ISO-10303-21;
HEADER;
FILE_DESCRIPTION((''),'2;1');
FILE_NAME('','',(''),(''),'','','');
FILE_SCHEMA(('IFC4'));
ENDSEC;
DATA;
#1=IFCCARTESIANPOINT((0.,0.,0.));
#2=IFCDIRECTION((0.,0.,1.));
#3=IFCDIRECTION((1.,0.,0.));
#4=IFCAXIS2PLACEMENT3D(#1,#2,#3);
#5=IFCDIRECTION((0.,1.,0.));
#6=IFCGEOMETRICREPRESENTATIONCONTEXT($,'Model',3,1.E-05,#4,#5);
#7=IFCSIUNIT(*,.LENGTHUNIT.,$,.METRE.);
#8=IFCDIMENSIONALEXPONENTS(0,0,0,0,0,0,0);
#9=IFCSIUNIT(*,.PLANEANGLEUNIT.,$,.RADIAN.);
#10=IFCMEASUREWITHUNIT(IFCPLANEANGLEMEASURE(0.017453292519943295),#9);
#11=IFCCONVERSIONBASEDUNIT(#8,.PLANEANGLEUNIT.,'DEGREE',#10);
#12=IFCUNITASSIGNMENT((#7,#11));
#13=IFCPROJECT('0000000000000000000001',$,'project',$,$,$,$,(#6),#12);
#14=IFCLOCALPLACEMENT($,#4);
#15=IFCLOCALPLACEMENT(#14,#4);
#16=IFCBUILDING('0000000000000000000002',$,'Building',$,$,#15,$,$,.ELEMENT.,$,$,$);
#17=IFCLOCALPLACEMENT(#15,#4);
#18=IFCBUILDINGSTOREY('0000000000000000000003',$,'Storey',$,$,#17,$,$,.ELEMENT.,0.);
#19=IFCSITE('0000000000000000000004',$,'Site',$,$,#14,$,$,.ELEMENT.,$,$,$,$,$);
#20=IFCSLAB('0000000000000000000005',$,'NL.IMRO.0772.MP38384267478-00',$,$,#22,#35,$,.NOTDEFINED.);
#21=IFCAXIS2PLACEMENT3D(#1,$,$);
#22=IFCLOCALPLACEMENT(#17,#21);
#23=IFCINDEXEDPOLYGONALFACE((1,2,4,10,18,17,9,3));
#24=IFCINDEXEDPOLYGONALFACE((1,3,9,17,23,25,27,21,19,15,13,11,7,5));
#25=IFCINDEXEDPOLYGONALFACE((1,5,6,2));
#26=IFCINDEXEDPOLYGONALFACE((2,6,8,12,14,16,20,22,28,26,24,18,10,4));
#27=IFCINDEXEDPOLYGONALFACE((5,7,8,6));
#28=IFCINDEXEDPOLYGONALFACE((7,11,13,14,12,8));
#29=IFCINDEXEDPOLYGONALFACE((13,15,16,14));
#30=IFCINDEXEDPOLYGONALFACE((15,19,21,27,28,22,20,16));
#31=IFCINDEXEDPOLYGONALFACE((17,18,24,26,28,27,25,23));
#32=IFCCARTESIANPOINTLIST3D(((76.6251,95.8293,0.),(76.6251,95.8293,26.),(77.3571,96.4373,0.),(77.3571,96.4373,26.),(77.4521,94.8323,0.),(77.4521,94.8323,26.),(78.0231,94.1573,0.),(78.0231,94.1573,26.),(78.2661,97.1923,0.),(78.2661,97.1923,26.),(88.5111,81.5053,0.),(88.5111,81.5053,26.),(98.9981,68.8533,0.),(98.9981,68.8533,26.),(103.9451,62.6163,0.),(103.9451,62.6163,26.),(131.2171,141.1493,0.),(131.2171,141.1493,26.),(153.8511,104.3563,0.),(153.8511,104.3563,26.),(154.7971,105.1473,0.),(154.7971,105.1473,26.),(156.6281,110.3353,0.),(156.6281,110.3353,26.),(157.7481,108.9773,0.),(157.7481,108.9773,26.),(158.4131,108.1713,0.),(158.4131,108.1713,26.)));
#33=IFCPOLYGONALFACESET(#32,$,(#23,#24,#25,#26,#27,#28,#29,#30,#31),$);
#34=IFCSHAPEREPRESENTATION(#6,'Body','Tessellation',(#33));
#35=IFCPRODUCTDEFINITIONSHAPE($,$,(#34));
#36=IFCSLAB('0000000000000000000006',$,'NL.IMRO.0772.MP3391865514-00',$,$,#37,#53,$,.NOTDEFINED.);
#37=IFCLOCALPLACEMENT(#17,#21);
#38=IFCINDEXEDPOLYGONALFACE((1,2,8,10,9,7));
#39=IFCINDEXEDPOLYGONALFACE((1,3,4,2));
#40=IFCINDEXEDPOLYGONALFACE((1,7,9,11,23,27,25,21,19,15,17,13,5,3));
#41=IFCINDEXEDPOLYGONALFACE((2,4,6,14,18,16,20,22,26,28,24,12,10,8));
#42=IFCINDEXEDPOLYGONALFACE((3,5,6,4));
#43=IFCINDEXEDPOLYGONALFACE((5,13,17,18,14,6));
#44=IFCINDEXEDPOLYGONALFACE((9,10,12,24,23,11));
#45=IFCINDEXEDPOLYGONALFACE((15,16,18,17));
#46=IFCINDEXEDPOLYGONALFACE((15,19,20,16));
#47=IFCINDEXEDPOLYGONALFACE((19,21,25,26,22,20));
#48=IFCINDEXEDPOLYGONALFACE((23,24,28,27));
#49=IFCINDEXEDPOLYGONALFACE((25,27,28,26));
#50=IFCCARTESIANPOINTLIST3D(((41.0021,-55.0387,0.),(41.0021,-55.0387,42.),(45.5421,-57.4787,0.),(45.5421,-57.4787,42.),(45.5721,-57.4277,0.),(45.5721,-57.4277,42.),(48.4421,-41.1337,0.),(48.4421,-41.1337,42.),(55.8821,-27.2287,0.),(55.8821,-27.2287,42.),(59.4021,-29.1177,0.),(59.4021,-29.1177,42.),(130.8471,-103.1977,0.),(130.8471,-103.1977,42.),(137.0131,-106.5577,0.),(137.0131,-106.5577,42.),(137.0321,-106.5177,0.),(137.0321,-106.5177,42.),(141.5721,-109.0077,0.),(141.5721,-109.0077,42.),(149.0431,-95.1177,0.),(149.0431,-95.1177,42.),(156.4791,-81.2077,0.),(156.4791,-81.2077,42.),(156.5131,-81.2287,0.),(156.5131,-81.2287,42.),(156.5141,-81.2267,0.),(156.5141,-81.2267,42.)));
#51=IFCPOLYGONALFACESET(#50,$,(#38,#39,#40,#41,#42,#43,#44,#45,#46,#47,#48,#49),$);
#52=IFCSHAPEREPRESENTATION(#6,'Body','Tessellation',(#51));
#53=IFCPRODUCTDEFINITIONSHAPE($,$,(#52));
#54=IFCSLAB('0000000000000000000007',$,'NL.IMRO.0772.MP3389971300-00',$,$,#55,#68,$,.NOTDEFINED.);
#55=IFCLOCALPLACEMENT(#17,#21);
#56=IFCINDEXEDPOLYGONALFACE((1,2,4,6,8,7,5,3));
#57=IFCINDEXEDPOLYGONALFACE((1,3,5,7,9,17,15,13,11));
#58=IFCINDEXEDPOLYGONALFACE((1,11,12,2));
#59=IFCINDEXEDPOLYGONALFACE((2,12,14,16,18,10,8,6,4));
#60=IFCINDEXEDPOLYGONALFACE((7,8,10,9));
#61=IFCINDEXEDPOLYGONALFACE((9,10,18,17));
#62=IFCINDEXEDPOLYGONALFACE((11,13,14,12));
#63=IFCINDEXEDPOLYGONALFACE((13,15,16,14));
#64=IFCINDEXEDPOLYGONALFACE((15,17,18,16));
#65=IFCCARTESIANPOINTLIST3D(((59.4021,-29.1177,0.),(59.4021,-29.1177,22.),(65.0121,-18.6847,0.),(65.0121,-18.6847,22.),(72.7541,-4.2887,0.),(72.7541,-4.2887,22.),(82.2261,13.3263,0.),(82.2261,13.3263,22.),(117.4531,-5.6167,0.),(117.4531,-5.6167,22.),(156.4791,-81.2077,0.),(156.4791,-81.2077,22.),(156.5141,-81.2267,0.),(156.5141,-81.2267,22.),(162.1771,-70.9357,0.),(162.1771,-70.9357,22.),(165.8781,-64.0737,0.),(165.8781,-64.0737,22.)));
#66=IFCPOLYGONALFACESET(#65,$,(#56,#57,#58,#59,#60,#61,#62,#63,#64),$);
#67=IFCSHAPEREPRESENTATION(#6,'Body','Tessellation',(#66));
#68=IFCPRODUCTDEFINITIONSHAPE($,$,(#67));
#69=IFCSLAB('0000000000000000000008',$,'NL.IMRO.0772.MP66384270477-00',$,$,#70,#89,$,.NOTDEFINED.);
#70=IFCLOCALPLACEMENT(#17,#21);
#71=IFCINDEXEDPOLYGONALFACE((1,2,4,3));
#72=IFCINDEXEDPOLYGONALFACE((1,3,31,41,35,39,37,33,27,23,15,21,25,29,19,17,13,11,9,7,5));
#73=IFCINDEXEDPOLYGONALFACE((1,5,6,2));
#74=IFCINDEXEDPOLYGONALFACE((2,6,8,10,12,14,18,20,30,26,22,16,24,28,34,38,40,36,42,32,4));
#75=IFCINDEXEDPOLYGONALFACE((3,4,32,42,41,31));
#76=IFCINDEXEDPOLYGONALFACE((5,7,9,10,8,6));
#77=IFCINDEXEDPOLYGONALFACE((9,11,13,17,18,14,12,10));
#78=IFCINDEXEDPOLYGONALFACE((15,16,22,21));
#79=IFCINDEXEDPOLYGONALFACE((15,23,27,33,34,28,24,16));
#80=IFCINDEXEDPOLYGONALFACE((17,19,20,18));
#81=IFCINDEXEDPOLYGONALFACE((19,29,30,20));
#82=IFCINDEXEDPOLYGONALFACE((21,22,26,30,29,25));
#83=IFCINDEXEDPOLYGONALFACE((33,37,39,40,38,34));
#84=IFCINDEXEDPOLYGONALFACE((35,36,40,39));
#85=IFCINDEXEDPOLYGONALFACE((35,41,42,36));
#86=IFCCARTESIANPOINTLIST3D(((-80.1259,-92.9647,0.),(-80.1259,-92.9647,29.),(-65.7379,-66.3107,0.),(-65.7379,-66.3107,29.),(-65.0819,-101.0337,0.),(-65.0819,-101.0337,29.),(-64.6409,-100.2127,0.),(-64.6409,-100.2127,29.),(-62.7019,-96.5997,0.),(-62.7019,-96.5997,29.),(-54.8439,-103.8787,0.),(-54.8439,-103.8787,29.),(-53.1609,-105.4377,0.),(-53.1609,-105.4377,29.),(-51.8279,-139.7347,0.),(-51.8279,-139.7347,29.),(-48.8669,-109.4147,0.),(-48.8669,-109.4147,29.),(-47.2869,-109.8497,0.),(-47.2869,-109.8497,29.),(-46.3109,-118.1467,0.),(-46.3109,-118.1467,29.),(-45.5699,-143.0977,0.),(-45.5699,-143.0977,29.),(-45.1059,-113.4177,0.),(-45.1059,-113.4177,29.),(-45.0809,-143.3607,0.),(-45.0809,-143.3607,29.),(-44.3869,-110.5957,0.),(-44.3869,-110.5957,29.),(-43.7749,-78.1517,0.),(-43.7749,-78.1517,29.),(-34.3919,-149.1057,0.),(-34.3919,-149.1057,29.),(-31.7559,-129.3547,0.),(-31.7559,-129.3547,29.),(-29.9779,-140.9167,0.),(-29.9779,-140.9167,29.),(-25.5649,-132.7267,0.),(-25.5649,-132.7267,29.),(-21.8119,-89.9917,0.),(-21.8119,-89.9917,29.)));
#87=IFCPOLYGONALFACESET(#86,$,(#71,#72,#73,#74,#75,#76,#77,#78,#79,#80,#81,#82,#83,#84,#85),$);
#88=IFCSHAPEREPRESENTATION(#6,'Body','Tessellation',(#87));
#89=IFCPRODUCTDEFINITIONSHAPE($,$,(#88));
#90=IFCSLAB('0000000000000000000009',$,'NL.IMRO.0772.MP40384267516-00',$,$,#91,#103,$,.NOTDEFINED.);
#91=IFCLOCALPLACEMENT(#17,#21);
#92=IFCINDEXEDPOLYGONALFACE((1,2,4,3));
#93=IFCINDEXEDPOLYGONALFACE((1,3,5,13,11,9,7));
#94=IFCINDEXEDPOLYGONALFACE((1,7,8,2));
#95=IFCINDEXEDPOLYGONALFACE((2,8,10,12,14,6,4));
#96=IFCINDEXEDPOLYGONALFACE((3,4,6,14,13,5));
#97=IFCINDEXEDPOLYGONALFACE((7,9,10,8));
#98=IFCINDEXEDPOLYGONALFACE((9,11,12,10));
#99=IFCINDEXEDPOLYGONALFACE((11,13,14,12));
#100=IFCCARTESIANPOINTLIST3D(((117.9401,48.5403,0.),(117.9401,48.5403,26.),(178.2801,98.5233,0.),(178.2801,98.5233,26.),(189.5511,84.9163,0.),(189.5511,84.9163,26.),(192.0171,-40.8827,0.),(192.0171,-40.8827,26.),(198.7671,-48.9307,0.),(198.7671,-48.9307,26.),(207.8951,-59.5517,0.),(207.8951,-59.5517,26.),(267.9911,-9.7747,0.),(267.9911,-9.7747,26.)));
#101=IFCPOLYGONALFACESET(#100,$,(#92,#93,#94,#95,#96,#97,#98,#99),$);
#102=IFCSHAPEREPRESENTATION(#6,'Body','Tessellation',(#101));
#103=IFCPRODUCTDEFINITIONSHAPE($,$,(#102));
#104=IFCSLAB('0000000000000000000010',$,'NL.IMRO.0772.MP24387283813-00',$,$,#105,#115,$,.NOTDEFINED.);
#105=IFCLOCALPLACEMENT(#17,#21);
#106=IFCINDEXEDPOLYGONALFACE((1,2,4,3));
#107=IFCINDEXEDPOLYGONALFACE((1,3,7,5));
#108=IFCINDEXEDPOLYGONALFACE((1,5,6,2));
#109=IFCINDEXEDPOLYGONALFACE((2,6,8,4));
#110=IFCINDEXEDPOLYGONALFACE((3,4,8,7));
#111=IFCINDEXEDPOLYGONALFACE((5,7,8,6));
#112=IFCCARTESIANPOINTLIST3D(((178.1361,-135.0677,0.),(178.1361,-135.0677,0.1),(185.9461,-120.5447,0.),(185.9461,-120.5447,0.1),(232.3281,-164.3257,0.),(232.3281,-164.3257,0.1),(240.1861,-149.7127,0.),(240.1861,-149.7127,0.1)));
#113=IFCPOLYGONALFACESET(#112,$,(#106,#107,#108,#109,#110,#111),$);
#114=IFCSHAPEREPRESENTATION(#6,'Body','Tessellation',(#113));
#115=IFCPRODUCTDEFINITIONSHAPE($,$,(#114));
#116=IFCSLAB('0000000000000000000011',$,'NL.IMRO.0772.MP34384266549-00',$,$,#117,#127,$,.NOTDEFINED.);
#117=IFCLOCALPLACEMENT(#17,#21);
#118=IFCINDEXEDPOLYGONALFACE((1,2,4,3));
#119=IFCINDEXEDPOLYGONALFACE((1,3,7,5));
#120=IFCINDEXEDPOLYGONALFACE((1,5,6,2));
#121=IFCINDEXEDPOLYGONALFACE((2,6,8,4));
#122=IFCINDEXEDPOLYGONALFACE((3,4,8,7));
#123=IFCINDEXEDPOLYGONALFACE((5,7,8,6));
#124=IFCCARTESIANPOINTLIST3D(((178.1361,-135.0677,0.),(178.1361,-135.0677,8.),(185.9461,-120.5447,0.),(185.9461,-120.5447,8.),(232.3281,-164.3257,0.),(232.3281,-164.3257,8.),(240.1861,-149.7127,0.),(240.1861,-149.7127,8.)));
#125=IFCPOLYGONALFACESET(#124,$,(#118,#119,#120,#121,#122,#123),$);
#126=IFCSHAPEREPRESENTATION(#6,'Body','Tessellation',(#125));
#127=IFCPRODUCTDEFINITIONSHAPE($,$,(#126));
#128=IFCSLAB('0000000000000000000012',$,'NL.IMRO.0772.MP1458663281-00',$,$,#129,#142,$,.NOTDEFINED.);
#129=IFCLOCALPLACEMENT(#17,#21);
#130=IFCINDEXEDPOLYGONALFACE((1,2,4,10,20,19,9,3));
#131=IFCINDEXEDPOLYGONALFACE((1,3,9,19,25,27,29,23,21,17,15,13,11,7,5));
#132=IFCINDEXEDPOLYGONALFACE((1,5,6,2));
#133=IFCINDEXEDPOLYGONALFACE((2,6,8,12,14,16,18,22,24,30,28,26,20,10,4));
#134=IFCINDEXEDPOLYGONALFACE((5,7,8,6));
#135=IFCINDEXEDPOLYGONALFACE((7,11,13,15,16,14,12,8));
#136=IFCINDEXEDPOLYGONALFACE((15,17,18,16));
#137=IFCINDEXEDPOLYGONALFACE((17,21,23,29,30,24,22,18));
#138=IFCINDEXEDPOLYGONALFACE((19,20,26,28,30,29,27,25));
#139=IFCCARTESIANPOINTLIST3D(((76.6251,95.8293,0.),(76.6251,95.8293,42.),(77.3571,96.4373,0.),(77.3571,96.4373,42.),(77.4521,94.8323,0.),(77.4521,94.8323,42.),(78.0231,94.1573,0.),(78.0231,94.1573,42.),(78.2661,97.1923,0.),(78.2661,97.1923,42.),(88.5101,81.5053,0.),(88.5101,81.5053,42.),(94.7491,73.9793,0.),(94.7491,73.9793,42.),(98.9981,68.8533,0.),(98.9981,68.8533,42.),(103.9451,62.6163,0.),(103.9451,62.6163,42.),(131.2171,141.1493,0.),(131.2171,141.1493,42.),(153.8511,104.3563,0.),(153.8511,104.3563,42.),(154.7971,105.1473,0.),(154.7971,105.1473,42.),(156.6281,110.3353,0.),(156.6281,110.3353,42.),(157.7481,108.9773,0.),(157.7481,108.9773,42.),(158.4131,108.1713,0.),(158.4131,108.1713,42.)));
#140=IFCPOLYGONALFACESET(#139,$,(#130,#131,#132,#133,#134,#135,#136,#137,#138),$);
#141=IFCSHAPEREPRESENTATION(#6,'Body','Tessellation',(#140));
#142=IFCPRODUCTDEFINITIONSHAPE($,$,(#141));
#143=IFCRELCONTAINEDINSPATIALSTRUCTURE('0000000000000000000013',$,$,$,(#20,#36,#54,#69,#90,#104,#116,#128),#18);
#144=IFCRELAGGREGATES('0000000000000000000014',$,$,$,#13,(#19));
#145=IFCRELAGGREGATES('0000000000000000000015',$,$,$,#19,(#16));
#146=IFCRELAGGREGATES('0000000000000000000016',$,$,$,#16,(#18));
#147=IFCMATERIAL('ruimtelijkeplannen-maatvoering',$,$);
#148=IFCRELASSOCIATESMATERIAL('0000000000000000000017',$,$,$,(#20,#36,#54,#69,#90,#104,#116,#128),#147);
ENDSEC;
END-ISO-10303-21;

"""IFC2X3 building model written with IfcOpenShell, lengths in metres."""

from ifc_helpers import new_model, entity, si_unit, converted_unit, direction, origin_with_axes, place, context, project, spatial, polyline, outline, extrude, material, element, save


model = new_model("IFC2X3")

# Units and contexts
model_context = context("Model", 3, precision=1e-05, world=origin_with_axes(), true_north=direction((0.0, 1.0, 0.0)))
ifc_project = project(units=[si_unit("LENGTHUNIT", "METRE"), converted_unit("PLANEANGLEUNIT", "DEGREE", entity("IfcPlaneAngleMeasure", 0.017453292519943295), si_unit("PLANEANGLEUNIT", "RADIAN"), dimensions=[0, 0, 0, 0, 0, 0, 0])], contexts=[model_context])

# Site, building, storey
site_placement = place(None, origin_with_axes())
site = spatial("IfcSite", under=ifc_project, at=site_placement, Name="Site", CompositionType="ELEMENT")
building_placement = place(site_placement, origin_with_axes())
building = spatial("IfcBuilding", under=site, at=building_placement, Name="Building", CompositionType="ELEMENT")
storey_placement = place(building_placement, origin_with_axes())
storey = spatial("IfcBuildingStorey", under=building, at=storey_placement, Name="Storey", CompositionType="ELEMENT", Elevation=0.0)

# Slabs
ifc_material = material(Name="ruimtelijkeplannen-maatvoering")
slab_1_placement = place(storey_placement, origin_with_axes())
element("IfcSlab", 1, at=slab_1_placement, inside=storey, material=ifc_material, Name="NL.IMRO.0772.MP38384267478-00", PredefinedType="NOTDEFINED", context=model_context, shape_type="SweptSolid", body=[
    extrude(outline(polyline([(77.3571, 96.4373), (78.2661, 97.1923), (131.2171, 141.1493), (156.6281, 110.3353), (157.7481, 108.9773), (158.4131, 108.1713), (154.7971, 105.1473), (153.8511, 104.3563), (103.9451, 62.6163), (98.9981, 68.8533), (88.5111, 81.5053), (78.0231, 94.1573), (77.4521, 94.8323), (76.6251, 95.8293), (77.3571, 96.4373)])), origin_with_axes(), (0.0, 0.0, 1.0), 26.0),
])
slab_2_placement = place(storey_placement, origin_with_axes())
element("IfcSlab", 2, at=slab_2_placement, inside=storey, material=ifc_material, Name="NL.IMRO.0772.MP3391865514-00", PredefinedType="NOTDEFINED", context=model_context, shape_type="SweptSolid", body=[
    extrude(outline(polyline([(156.5131, -81.2287), (149.0431, -95.1177), (141.5721, -109.0077), (137.0131, -106.5577), (137.0321, -106.5177), (130.8471, -103.1977), (45.5721, -57.4277), (45.5421, -57.4787), (41.0021, -55.0387), (48.4421, -41.1337), (55.8821, -27.2287), (59.4021, -29.1177), (156.4791, -81.2077), (156.5141, -81.2267), (156.5131, -81.2287)])), origin_with_axes(), (0.0, 0.0, 1.0), 42.0),
])
slab_3_placement = place(storey_placement, origin_with_axes())
element("IfcSlab", 3, at=slab_3_placement, inside=storey, material=ifc_material, Name="NL.IMRO.0772.MP3389971300-00", PredefinedType="NOTDEFINED", context=model_context, shape_type="SweptSolid", body=[
    extrude(outline(polyline([(156.5141, -81.2267), (156.4791, -81.2077), (59.4021, -29.1177), (65.0121, -18.6847), (72.7541, -4.2887), (82.2261, 13.3263), (117.4531, -5.6167), (165.8781, -64.0737), (162.1771, -70.9357), (156.5141, -81.2267)])), origin_with_axes(), (0.0, 0.0, 1.0), 22.0),
])
slab_4_placement = place(storey_placement, origin_with_axes())
element("IfcSlab", 4, at=slab_4_placement, inside=storey, material=ifc_material, Name="NL.IMRO.0772.MP66384270477-00", PredefinedType="NOTDEFINED", context=model_context, shape_type="SweptSolid", body=[
    extrude(outline(polyline([(-80.1259, -92.9647), (-65.7379, -66.3107), (-43.7749, -78.1517), (-21.8119, -89.9917), (-31.7559, -129.3547), (-25.5649, -132.7267), (-29.9779, -140.9167), (-34.3919, -149.1057), (-45.0809, -143.3607), (-45.5699, -143.0977), (-51.8279, -139.7347), (-46.3109, -118.1467), (-45.1059, -113.4177), (-44.3869, -110.5957), (-47.2869, -109.8497), (-48.8669, -109.4147), (-53.1609, -105.4377), (-54.8439, -103.8787), (-62.7019, -96.5997), (-64.6409, -100.2127), (-65.0819, -101.0337), (-80.1259, -92.9647)])), origin_with_axes(), (0.0, 0.0, 1.0), 29.0),
])
slab_5_placement = place(storey_placement, origin_with_axes())
element("IfcSlab", 5, at=slab_5_placement, inside=storey, material=ifc_material, Name="NL.IMRO.0772.MP40384267516-00", PredefinedType="NOTDEFINED", context=model_context, shape_type="SweptSolid", body=[
    extrude(outline(polyline([(178.2801, 98.5233), (189.5511, 84.9163), (267.9911, -9.7747), (207.8951, -59.5517), (198.7671, -48.9307), (192.0171, -40.8827), (117.9401, 48.5403), (178.2801, 98.5233)])), origin_with_axes(), (0.0, 0.0, 1.0), 26.0),
])
slab_6_placement = place(storey_placement, origin_with_axes())
element("IfcSlab", 6, at=slab_6_placement, inside=storey, material=ifc_material, Name="NL.IMRO.0772.MP24387283813-00", PredefinedType="NOTDEFINED", context=model_context, shape_type="SweptSolid", body=[
    extrude(outline(polyline([(240.1861, -149.7127), (232.3281, -164.3257), (178.1361, -135.0677), (185.9461, -120.5447), (240.1861, -149.7127)])), origin_with_axes(), (0.0, 0.0, 1.0), 0.1),
])
slab_7_placement = place(storey_placement, origin_with_axes())
element("IfcSlab", 7, at=slab_7_placement, inside=storey, material=ifc_material, Name="NL.IMRO.0772.MP34384266549-00", PredefinedType="NOTDEFINED", context=model_context, shape_type="SweptSolid", body=[
    extrude(outline(polyline([(240.1861, -149.7127), (232.3281, -164.3257), (178.1361, -135.0677), (185.9461, -120.5447), (240.1861, -149.7127)])), origin_with_axes(), (0.0, 0.0, 1.0), 8.0),
])
slab_8_placement = place(storey_placement, origin_with_axes())
element("IfcSlab", 8, at=slab_8_placement, inside=storey, material=ifc_material, Name="NL.IMRO.0772.MP1458663281-00", PredefinedType="NOTDEFINED", context=model_context, shape_type="SweptSolid", body=[
    extrude(outline(polyline([(94.7491, 73.9793), (88.5101, 81.5053), (78.0231, 94.1573), (77.4521, 94.8323), (76.6251, 95.8293), (77.3571, 96.4373), (78.2661, 97.1923), (131.2171, 141.1493), (156.6281, 110.3353), (157.7481, 108.9773), (158.4131, 108.1713), (154.7971, 105.1473), (153.8511, 104.3563), (103.9451, 62.6163), (98.9981, 68.8533), (94.7491, 73.9793)])), origin_with_axes(), (0.0, 0.0, 1.0), 42.0),
])

save(model, "model.ifc")
